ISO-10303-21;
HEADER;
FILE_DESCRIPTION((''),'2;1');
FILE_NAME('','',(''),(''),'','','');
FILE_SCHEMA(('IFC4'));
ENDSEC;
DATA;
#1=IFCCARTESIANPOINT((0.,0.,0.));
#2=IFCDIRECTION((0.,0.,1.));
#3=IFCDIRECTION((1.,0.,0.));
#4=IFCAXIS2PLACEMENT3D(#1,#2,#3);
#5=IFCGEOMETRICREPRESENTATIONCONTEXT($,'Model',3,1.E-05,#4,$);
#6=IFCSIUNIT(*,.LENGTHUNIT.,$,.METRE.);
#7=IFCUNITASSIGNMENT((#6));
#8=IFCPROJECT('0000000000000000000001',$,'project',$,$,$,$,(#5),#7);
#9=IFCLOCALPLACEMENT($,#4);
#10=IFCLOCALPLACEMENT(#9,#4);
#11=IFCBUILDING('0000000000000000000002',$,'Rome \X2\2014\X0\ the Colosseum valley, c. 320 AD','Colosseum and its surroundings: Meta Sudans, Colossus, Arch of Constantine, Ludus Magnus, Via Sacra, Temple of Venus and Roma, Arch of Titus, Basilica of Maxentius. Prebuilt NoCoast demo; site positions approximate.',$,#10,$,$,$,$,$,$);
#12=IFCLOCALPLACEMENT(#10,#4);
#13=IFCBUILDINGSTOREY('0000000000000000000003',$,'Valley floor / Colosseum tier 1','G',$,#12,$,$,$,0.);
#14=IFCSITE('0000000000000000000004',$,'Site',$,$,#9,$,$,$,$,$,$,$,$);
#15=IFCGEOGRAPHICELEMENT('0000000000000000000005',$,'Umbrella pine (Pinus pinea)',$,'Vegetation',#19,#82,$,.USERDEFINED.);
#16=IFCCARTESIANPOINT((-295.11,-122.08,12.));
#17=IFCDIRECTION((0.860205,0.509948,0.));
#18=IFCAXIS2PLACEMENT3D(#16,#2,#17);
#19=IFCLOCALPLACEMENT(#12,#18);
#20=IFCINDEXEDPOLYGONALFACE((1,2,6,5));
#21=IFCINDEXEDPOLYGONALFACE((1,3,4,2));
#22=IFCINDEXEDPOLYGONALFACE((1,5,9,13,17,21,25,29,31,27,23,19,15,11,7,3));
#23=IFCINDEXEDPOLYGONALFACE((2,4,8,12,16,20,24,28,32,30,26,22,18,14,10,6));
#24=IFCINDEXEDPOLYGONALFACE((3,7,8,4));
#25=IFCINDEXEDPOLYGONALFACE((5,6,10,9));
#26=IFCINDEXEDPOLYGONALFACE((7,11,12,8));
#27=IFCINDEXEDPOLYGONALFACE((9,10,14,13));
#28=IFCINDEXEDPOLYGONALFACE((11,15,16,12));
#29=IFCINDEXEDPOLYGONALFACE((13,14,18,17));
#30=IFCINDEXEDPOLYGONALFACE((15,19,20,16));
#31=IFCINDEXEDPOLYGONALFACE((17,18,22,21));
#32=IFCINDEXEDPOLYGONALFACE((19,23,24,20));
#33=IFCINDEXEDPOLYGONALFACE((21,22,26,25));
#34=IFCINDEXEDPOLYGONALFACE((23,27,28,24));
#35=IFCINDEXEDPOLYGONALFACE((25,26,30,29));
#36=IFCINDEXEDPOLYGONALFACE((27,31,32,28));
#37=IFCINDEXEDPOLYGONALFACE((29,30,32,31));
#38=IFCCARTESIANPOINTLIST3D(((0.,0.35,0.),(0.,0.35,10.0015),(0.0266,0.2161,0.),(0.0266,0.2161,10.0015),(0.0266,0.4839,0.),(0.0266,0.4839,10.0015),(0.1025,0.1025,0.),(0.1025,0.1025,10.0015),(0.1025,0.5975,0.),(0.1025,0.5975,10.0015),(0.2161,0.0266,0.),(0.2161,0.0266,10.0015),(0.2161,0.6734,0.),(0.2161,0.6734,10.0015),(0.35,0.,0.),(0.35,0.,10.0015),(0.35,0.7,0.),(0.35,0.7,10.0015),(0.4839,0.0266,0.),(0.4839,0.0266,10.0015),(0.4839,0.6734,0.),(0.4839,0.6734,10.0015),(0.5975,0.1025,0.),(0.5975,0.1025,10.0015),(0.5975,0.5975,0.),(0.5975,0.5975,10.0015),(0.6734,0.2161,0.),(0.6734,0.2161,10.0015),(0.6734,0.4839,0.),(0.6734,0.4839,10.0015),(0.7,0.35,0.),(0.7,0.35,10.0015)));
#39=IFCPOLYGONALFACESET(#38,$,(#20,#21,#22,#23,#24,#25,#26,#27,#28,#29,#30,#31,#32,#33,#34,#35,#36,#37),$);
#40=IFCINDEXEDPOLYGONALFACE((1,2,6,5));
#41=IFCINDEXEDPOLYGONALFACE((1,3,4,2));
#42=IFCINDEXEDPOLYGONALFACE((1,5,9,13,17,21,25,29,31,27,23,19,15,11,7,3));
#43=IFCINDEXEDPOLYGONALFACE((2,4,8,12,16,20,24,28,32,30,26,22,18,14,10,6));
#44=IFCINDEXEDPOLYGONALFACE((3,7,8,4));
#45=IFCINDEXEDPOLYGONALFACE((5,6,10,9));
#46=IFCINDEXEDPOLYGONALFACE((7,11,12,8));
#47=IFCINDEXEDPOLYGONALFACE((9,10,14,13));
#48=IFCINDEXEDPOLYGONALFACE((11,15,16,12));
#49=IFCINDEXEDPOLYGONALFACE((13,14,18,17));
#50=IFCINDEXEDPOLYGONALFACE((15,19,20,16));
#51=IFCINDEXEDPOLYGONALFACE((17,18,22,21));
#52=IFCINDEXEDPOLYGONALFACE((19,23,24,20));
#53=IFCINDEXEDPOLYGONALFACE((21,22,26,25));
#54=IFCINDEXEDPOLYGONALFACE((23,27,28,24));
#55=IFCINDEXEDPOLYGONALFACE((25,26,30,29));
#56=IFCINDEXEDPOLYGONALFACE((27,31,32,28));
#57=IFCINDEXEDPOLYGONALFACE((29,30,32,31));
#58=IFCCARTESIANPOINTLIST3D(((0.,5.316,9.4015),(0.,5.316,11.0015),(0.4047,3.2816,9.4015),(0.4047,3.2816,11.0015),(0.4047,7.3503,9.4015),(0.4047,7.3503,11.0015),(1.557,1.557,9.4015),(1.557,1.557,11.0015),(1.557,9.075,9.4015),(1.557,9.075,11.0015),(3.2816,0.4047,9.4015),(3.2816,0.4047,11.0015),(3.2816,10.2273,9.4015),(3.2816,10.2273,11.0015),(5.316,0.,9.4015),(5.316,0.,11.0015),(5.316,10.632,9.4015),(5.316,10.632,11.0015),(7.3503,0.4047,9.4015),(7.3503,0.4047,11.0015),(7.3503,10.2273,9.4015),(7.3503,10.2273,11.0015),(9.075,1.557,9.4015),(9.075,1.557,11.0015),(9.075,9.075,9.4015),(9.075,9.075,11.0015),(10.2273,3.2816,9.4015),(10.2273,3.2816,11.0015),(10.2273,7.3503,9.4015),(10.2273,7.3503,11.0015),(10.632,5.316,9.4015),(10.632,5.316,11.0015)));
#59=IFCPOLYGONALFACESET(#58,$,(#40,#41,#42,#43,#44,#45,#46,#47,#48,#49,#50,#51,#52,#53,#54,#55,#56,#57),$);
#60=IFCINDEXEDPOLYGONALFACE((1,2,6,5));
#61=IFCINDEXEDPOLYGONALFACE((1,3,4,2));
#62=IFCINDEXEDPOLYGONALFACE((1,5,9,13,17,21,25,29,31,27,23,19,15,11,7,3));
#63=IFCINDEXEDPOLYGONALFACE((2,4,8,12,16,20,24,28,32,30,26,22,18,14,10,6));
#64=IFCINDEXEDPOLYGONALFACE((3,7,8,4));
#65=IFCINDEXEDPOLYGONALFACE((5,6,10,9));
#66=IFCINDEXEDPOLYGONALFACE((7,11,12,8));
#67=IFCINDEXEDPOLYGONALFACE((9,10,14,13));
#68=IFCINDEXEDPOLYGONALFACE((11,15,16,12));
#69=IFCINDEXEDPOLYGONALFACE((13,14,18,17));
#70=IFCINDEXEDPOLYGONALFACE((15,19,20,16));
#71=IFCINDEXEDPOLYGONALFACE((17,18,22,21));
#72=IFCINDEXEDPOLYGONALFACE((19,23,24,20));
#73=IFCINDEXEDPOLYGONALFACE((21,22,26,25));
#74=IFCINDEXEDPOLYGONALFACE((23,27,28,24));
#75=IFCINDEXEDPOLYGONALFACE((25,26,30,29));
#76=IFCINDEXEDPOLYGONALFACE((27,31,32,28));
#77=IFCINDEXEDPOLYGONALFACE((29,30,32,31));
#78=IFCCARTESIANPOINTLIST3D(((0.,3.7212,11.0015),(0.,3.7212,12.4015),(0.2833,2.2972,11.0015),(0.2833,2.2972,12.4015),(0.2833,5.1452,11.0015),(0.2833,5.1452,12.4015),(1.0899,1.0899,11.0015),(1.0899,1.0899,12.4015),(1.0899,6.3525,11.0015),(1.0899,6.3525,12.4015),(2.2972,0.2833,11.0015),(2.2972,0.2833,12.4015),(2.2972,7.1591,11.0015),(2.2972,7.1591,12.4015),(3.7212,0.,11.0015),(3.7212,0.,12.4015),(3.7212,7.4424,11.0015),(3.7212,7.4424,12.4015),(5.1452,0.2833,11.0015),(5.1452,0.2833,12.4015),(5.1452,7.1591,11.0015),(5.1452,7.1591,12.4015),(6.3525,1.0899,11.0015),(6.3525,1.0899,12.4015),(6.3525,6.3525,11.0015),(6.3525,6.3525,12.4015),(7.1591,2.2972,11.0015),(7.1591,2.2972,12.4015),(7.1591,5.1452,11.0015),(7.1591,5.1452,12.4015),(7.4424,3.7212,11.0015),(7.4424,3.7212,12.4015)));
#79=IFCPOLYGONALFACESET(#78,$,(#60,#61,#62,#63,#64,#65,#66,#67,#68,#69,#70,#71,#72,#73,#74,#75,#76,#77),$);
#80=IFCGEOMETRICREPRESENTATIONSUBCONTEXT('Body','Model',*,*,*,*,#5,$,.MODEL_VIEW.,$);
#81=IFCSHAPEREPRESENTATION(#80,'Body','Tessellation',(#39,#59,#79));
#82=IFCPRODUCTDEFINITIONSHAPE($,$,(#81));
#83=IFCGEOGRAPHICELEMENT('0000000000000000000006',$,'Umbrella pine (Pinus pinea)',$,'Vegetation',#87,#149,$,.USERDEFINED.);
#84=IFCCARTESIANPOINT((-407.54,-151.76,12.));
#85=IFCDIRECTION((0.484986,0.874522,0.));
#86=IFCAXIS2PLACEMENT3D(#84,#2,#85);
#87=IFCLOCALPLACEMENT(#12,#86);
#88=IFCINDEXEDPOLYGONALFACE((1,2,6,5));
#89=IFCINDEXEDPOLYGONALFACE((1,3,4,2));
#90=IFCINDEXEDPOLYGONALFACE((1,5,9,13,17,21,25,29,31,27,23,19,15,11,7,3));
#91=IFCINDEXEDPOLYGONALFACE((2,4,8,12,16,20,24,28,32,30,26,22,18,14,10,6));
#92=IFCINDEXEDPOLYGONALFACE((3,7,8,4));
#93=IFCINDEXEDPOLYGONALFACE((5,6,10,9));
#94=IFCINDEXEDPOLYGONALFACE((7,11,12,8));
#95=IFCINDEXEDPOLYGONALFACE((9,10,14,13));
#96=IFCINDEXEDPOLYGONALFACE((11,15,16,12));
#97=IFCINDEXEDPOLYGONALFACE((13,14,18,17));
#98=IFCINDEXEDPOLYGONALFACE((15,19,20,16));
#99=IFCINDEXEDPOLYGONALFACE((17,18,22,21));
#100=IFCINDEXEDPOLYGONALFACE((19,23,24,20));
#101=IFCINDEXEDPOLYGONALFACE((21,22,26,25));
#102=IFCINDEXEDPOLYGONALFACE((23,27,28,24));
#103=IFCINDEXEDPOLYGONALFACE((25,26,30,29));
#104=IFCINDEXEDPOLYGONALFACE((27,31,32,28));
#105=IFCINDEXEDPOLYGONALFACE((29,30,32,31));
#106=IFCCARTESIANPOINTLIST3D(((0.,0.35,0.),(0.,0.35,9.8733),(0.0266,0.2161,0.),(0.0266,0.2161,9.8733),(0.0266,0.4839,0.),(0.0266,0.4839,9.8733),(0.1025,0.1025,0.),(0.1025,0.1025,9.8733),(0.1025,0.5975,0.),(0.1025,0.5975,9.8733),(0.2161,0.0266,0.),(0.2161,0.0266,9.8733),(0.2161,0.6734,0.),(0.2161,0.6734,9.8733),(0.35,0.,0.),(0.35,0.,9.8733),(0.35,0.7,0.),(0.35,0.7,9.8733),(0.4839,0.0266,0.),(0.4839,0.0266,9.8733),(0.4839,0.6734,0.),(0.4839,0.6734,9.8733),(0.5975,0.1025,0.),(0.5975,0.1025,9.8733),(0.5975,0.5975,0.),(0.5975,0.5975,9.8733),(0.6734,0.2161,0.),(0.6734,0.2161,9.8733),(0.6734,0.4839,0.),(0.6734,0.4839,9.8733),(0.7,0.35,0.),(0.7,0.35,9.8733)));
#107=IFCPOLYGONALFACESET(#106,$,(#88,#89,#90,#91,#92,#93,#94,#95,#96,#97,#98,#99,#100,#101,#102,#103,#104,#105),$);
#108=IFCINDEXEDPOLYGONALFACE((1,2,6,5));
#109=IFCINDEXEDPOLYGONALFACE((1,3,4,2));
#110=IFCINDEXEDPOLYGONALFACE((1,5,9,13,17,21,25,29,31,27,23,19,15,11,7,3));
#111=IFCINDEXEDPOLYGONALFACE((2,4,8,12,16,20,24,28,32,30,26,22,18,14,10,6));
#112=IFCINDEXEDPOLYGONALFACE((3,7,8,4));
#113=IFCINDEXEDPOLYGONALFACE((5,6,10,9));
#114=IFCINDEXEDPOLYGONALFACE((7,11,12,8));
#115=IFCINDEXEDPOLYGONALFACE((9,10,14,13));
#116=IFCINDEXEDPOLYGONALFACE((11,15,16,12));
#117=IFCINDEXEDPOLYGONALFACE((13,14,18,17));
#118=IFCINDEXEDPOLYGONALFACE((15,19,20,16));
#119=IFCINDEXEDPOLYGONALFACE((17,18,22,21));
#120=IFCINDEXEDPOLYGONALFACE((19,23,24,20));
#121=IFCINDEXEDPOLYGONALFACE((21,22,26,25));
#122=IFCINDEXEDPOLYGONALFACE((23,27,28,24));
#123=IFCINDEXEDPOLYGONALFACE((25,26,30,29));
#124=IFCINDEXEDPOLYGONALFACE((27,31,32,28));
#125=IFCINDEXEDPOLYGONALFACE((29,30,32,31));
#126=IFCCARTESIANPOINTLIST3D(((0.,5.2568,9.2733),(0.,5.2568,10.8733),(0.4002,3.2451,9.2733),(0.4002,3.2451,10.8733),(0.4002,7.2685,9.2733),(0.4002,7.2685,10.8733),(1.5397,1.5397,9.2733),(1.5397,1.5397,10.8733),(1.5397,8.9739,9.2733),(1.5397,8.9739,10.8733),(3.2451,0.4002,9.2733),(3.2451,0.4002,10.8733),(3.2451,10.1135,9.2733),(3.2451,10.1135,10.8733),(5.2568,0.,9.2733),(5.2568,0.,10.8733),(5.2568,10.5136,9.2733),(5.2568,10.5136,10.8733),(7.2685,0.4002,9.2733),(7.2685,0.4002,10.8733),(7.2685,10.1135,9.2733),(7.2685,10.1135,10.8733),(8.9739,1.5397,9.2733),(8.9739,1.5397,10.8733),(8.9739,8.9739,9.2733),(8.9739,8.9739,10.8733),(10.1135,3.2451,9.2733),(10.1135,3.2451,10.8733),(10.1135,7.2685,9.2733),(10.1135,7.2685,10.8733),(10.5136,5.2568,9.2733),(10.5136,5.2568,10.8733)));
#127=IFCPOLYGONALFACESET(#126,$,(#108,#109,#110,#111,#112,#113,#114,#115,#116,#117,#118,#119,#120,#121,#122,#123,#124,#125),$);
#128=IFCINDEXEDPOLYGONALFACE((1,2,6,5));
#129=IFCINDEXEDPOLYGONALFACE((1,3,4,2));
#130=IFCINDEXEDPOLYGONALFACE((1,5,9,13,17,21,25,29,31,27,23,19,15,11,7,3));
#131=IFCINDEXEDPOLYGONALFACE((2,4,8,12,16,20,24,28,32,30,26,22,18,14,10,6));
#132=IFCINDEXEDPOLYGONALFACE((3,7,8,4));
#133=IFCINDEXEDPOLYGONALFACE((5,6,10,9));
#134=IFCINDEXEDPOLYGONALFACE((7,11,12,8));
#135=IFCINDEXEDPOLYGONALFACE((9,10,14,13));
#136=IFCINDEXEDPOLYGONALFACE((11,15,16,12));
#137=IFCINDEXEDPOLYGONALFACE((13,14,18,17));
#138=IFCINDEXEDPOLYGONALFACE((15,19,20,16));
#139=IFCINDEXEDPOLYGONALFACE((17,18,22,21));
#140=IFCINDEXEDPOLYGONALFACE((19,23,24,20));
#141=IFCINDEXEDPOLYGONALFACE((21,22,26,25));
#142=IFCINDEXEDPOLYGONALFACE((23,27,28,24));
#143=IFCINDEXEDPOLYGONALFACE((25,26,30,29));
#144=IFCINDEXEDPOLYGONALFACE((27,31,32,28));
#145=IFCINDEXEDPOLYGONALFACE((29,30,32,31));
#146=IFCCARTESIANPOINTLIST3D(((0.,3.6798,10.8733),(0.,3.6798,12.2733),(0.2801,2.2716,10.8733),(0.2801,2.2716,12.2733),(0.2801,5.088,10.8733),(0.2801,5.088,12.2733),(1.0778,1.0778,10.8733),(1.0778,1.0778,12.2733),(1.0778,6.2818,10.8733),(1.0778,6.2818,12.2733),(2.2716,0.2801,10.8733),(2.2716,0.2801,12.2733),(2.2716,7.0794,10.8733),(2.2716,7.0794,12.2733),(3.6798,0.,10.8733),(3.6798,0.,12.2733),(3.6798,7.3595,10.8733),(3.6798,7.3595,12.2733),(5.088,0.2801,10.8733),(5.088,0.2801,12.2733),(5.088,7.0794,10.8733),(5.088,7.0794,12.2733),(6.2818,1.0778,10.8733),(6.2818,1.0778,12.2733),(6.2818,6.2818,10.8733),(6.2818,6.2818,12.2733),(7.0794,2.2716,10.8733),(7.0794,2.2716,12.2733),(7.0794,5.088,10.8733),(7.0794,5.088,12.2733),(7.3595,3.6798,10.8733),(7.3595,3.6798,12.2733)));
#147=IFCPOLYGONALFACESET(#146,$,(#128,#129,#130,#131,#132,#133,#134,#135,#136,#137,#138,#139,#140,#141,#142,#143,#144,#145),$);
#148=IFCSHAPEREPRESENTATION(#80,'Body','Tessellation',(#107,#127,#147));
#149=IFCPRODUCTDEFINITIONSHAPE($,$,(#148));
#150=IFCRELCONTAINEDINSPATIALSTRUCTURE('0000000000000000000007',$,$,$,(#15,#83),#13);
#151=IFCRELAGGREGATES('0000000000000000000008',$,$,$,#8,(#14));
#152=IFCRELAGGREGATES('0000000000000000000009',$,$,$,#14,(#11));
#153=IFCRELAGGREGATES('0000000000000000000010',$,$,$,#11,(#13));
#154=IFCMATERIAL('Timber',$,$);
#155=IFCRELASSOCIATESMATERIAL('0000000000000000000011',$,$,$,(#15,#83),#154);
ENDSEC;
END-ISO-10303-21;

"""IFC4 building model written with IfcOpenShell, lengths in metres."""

from ifc_helpers import new_model, si_unit, frame, origin_with_axes, place, context, subcontext, project, spatial, polyline, outline, extrude, material, element, save


model = new_model("IFC4")

# Units and contexts
model_context = context("Model", 3, precision=1e-05, world=origin_with_axes())
body_context = subcontext(model_context, "Body", "Model", "MODEL_VIEW")
ifc_project = project(units=[si_unit("LENGTHUNIT", "METRE")], contexts=[model_context])

# Site, building, storey
site_placement = place(None, origin_with_axes())
site = spatial("IfcSite", under=ifc_project, at=site_placement, Name="Site")
building_placement = place(site_placement, origin_with_axes())
building = spatial("IfcBuilding", under=site, at=building_placement, Name="Rome — the Colosseum valley, c. 320 AD", Description="Colosseum and its surroundings: Meta Sudans, Colossus, Arch of Constantine, Ludus Magnus, Via Sacra, Temple of Venus and Roma, Arch of Titus, Basilica of Maxentius. Prebuilt NoCoast demo; site positions approximate.")
storey_placement = place(building_placement, origin_with_axes())
storey = spatial("IfcBuildingStorey", under=building, at=storey_placement, Name="Valley floor / Colosseum tier 1", Description="G", Elevation=0.0)

# Shared definitions
ifc_material_1 = material(Name="Timber")

# Geographic elements
geographic_element_1_placement = place(storey_placement, frame((-295.11, -122.08, 12.0), z_axis=(0.0, 0.0, 1.0), x_axis=(0.860205, 0.509948, 0.0)))
element("IfcGeographicElement", 1, at=geographic_element_1_placement, inside=storey, material=ifc_material_1, Name="Umbrella pine (Pinus pinea)", ObjectType="Vegetation", PredefinedType="USERDEFINED", context=body_context, shape_type="SweptSolid", body=[
    extrude(outline(polyline([(0.7, 0.35), (0.6734, 0.4839), (0.5975, 0.5975), (0.4839, 0.6734), (0.35, 0.7), (0.2161, 0.6734), (0.1025, 0.5975), (0.0266, 0.4839), (0.0, 0.35), (0.0266, 0.2161), (0.1025, 0.1025), (0.2161, 0.0266), (0.35, 0.0), (0.4839, 0.0266), (0.5975, 0.1025), (0.6734, 0.2161), (0.7, 0.35)])), origin_with_axes(), (0.0, 0.0, 1.0), 10.0015),
    extrude(outline(polyline([(10.632, 5.316), (10.2273, 7.3503), (9.075, 9.075), (7.3503, 10.2273), (5.316, 10.632), (3.2816, 10.2273), (1.557, 9.075), (0.4047, 7.3503), (0.0, 5.316), (0.4047, 3.2816), (1.557, 1.557), (3.2816, 0.4047), (5.316, 0.0), (7.3503, 0.4047), (9.075, 1.557), (10.2273, 3.2816), (10.632, 5.316)])), frame((0.0, 0.0, 9.4015), z_axis=(0.0, 0.0, 1.0), x_axis=(1.0, 0.0, 0.0)), (0.0, 0.0, 1.0), 1.6),
    extrude(outline(polyline([(7.4424, 3.7212), (7.1591, 5.1452), (6.3525, 6.3525), (5.1452, 7.1591), (3.7212, 7.4424), (2.2972, 7.1591), (1.0899, 6.3525), (0.2833, 5.1452), (0.0, 3.7212), (0.2833, 2.2972), (1.0899, 1.0899), (2.2972, 0.2833), (3.7212, 0.0), (5.1452, 0.2833), (6.3525, 1.0899), (7.1591, 2.2972), (7.4424, 3.7212)])), frame((0.0, 0.0, 11.0015), z_axis=(0.0, 0.0, 1.0), x_axis=(1.0, 0.0, 0.0)), (0.0, 0.0, 1.0), 1.4),
])
geographic_element_2_placement = place(storey_placement, frame((-407.54, -151.76, 12.0), z_axis=(0.0, 0.0, 1.0), x_axis=(0.484986, 0.874522, 0.0)))
element("IfcGeographicElement", 2, at=geographic_element_2_placement, inside=storey, material=ifc_material_1, Name="Umbrella pine (Pinus pinea)", ObjectType="Vegetation", PredefinedType="USERDEFINED", context=body_context, shape_type="SweptSolid", body=[
    extrude(outline(polyline([(0.7, 0.35), (0.6734, 0.4839), (0.5975, 0.5975), (0.4839, 0.6734), (0.35, 0.7), (0.2161, 0.6734), (0.1025, 0.5975), (0.0266, 0.4839), (0.0, 0.35), (0.0266, 0.2161), (0.1025, 0.1025), (0.2161, 0.0266), (0.35, 0.0), (0.4839, 0.0266), (0.5975, 0.1025), (0.6734, 0.2161), (0.7, 0.35)])), origin_with_axes(), (0.0, 0.0, 1.0), 9.8733),
    extrude(outline(polyline([(10.5136, 5.2568), (10.1135, 7.2685), (8.9739, 8.9739), (7.2685, 10.1135), (5.2568, 10.5136), (3.2451, 10.1135), (1.5397, 8.9739), (0.4002, 7.2685), (0.0, 5.2568), (0.4002, 3.2451), (1.5397, 1.5397), (3.2451, 0.4002), (5.2568, 0.0), (7.2685, 0.4002), (8.9739, 1.5397), (10.1135, 3.2451), (10.5136, 5.2568)])), frame((0.0, 0.0, 9.2733), z_axis=(0.0, 0.0, 1.0), x_axis=(1.0, 0.0, 0.0)), (0.0, 0.0, 1.0), 1.6),
    extrude(outline(polyline([(7.3595, 3.6798), (7.0794, 5.088), (6.2818, 6.2818), (5.088, 7.0794), (3.6798, 7.3595), (2.2716, 7.0794), (1.0778, 6.2818), (0.2801, 5.088), (0.0, 3.6798), (0.2801, 2.2716), (1.0778, 1.0778), (2.2716, 0.2801), (3.6798, 0.0), (5.088, 0.2801), (6.2818, 1.0778), (7.0794, 2.2716), (7.3595, 3.6798)])), frame((0.0, 0.0, 10.8733), z_axis=(0.0, 0.0, 1.0), x_axis=(1.0, 0.0, 0.0)), (0.0, 0.0, 1.0), 1.4),
])

save(model, "model.ifc")
